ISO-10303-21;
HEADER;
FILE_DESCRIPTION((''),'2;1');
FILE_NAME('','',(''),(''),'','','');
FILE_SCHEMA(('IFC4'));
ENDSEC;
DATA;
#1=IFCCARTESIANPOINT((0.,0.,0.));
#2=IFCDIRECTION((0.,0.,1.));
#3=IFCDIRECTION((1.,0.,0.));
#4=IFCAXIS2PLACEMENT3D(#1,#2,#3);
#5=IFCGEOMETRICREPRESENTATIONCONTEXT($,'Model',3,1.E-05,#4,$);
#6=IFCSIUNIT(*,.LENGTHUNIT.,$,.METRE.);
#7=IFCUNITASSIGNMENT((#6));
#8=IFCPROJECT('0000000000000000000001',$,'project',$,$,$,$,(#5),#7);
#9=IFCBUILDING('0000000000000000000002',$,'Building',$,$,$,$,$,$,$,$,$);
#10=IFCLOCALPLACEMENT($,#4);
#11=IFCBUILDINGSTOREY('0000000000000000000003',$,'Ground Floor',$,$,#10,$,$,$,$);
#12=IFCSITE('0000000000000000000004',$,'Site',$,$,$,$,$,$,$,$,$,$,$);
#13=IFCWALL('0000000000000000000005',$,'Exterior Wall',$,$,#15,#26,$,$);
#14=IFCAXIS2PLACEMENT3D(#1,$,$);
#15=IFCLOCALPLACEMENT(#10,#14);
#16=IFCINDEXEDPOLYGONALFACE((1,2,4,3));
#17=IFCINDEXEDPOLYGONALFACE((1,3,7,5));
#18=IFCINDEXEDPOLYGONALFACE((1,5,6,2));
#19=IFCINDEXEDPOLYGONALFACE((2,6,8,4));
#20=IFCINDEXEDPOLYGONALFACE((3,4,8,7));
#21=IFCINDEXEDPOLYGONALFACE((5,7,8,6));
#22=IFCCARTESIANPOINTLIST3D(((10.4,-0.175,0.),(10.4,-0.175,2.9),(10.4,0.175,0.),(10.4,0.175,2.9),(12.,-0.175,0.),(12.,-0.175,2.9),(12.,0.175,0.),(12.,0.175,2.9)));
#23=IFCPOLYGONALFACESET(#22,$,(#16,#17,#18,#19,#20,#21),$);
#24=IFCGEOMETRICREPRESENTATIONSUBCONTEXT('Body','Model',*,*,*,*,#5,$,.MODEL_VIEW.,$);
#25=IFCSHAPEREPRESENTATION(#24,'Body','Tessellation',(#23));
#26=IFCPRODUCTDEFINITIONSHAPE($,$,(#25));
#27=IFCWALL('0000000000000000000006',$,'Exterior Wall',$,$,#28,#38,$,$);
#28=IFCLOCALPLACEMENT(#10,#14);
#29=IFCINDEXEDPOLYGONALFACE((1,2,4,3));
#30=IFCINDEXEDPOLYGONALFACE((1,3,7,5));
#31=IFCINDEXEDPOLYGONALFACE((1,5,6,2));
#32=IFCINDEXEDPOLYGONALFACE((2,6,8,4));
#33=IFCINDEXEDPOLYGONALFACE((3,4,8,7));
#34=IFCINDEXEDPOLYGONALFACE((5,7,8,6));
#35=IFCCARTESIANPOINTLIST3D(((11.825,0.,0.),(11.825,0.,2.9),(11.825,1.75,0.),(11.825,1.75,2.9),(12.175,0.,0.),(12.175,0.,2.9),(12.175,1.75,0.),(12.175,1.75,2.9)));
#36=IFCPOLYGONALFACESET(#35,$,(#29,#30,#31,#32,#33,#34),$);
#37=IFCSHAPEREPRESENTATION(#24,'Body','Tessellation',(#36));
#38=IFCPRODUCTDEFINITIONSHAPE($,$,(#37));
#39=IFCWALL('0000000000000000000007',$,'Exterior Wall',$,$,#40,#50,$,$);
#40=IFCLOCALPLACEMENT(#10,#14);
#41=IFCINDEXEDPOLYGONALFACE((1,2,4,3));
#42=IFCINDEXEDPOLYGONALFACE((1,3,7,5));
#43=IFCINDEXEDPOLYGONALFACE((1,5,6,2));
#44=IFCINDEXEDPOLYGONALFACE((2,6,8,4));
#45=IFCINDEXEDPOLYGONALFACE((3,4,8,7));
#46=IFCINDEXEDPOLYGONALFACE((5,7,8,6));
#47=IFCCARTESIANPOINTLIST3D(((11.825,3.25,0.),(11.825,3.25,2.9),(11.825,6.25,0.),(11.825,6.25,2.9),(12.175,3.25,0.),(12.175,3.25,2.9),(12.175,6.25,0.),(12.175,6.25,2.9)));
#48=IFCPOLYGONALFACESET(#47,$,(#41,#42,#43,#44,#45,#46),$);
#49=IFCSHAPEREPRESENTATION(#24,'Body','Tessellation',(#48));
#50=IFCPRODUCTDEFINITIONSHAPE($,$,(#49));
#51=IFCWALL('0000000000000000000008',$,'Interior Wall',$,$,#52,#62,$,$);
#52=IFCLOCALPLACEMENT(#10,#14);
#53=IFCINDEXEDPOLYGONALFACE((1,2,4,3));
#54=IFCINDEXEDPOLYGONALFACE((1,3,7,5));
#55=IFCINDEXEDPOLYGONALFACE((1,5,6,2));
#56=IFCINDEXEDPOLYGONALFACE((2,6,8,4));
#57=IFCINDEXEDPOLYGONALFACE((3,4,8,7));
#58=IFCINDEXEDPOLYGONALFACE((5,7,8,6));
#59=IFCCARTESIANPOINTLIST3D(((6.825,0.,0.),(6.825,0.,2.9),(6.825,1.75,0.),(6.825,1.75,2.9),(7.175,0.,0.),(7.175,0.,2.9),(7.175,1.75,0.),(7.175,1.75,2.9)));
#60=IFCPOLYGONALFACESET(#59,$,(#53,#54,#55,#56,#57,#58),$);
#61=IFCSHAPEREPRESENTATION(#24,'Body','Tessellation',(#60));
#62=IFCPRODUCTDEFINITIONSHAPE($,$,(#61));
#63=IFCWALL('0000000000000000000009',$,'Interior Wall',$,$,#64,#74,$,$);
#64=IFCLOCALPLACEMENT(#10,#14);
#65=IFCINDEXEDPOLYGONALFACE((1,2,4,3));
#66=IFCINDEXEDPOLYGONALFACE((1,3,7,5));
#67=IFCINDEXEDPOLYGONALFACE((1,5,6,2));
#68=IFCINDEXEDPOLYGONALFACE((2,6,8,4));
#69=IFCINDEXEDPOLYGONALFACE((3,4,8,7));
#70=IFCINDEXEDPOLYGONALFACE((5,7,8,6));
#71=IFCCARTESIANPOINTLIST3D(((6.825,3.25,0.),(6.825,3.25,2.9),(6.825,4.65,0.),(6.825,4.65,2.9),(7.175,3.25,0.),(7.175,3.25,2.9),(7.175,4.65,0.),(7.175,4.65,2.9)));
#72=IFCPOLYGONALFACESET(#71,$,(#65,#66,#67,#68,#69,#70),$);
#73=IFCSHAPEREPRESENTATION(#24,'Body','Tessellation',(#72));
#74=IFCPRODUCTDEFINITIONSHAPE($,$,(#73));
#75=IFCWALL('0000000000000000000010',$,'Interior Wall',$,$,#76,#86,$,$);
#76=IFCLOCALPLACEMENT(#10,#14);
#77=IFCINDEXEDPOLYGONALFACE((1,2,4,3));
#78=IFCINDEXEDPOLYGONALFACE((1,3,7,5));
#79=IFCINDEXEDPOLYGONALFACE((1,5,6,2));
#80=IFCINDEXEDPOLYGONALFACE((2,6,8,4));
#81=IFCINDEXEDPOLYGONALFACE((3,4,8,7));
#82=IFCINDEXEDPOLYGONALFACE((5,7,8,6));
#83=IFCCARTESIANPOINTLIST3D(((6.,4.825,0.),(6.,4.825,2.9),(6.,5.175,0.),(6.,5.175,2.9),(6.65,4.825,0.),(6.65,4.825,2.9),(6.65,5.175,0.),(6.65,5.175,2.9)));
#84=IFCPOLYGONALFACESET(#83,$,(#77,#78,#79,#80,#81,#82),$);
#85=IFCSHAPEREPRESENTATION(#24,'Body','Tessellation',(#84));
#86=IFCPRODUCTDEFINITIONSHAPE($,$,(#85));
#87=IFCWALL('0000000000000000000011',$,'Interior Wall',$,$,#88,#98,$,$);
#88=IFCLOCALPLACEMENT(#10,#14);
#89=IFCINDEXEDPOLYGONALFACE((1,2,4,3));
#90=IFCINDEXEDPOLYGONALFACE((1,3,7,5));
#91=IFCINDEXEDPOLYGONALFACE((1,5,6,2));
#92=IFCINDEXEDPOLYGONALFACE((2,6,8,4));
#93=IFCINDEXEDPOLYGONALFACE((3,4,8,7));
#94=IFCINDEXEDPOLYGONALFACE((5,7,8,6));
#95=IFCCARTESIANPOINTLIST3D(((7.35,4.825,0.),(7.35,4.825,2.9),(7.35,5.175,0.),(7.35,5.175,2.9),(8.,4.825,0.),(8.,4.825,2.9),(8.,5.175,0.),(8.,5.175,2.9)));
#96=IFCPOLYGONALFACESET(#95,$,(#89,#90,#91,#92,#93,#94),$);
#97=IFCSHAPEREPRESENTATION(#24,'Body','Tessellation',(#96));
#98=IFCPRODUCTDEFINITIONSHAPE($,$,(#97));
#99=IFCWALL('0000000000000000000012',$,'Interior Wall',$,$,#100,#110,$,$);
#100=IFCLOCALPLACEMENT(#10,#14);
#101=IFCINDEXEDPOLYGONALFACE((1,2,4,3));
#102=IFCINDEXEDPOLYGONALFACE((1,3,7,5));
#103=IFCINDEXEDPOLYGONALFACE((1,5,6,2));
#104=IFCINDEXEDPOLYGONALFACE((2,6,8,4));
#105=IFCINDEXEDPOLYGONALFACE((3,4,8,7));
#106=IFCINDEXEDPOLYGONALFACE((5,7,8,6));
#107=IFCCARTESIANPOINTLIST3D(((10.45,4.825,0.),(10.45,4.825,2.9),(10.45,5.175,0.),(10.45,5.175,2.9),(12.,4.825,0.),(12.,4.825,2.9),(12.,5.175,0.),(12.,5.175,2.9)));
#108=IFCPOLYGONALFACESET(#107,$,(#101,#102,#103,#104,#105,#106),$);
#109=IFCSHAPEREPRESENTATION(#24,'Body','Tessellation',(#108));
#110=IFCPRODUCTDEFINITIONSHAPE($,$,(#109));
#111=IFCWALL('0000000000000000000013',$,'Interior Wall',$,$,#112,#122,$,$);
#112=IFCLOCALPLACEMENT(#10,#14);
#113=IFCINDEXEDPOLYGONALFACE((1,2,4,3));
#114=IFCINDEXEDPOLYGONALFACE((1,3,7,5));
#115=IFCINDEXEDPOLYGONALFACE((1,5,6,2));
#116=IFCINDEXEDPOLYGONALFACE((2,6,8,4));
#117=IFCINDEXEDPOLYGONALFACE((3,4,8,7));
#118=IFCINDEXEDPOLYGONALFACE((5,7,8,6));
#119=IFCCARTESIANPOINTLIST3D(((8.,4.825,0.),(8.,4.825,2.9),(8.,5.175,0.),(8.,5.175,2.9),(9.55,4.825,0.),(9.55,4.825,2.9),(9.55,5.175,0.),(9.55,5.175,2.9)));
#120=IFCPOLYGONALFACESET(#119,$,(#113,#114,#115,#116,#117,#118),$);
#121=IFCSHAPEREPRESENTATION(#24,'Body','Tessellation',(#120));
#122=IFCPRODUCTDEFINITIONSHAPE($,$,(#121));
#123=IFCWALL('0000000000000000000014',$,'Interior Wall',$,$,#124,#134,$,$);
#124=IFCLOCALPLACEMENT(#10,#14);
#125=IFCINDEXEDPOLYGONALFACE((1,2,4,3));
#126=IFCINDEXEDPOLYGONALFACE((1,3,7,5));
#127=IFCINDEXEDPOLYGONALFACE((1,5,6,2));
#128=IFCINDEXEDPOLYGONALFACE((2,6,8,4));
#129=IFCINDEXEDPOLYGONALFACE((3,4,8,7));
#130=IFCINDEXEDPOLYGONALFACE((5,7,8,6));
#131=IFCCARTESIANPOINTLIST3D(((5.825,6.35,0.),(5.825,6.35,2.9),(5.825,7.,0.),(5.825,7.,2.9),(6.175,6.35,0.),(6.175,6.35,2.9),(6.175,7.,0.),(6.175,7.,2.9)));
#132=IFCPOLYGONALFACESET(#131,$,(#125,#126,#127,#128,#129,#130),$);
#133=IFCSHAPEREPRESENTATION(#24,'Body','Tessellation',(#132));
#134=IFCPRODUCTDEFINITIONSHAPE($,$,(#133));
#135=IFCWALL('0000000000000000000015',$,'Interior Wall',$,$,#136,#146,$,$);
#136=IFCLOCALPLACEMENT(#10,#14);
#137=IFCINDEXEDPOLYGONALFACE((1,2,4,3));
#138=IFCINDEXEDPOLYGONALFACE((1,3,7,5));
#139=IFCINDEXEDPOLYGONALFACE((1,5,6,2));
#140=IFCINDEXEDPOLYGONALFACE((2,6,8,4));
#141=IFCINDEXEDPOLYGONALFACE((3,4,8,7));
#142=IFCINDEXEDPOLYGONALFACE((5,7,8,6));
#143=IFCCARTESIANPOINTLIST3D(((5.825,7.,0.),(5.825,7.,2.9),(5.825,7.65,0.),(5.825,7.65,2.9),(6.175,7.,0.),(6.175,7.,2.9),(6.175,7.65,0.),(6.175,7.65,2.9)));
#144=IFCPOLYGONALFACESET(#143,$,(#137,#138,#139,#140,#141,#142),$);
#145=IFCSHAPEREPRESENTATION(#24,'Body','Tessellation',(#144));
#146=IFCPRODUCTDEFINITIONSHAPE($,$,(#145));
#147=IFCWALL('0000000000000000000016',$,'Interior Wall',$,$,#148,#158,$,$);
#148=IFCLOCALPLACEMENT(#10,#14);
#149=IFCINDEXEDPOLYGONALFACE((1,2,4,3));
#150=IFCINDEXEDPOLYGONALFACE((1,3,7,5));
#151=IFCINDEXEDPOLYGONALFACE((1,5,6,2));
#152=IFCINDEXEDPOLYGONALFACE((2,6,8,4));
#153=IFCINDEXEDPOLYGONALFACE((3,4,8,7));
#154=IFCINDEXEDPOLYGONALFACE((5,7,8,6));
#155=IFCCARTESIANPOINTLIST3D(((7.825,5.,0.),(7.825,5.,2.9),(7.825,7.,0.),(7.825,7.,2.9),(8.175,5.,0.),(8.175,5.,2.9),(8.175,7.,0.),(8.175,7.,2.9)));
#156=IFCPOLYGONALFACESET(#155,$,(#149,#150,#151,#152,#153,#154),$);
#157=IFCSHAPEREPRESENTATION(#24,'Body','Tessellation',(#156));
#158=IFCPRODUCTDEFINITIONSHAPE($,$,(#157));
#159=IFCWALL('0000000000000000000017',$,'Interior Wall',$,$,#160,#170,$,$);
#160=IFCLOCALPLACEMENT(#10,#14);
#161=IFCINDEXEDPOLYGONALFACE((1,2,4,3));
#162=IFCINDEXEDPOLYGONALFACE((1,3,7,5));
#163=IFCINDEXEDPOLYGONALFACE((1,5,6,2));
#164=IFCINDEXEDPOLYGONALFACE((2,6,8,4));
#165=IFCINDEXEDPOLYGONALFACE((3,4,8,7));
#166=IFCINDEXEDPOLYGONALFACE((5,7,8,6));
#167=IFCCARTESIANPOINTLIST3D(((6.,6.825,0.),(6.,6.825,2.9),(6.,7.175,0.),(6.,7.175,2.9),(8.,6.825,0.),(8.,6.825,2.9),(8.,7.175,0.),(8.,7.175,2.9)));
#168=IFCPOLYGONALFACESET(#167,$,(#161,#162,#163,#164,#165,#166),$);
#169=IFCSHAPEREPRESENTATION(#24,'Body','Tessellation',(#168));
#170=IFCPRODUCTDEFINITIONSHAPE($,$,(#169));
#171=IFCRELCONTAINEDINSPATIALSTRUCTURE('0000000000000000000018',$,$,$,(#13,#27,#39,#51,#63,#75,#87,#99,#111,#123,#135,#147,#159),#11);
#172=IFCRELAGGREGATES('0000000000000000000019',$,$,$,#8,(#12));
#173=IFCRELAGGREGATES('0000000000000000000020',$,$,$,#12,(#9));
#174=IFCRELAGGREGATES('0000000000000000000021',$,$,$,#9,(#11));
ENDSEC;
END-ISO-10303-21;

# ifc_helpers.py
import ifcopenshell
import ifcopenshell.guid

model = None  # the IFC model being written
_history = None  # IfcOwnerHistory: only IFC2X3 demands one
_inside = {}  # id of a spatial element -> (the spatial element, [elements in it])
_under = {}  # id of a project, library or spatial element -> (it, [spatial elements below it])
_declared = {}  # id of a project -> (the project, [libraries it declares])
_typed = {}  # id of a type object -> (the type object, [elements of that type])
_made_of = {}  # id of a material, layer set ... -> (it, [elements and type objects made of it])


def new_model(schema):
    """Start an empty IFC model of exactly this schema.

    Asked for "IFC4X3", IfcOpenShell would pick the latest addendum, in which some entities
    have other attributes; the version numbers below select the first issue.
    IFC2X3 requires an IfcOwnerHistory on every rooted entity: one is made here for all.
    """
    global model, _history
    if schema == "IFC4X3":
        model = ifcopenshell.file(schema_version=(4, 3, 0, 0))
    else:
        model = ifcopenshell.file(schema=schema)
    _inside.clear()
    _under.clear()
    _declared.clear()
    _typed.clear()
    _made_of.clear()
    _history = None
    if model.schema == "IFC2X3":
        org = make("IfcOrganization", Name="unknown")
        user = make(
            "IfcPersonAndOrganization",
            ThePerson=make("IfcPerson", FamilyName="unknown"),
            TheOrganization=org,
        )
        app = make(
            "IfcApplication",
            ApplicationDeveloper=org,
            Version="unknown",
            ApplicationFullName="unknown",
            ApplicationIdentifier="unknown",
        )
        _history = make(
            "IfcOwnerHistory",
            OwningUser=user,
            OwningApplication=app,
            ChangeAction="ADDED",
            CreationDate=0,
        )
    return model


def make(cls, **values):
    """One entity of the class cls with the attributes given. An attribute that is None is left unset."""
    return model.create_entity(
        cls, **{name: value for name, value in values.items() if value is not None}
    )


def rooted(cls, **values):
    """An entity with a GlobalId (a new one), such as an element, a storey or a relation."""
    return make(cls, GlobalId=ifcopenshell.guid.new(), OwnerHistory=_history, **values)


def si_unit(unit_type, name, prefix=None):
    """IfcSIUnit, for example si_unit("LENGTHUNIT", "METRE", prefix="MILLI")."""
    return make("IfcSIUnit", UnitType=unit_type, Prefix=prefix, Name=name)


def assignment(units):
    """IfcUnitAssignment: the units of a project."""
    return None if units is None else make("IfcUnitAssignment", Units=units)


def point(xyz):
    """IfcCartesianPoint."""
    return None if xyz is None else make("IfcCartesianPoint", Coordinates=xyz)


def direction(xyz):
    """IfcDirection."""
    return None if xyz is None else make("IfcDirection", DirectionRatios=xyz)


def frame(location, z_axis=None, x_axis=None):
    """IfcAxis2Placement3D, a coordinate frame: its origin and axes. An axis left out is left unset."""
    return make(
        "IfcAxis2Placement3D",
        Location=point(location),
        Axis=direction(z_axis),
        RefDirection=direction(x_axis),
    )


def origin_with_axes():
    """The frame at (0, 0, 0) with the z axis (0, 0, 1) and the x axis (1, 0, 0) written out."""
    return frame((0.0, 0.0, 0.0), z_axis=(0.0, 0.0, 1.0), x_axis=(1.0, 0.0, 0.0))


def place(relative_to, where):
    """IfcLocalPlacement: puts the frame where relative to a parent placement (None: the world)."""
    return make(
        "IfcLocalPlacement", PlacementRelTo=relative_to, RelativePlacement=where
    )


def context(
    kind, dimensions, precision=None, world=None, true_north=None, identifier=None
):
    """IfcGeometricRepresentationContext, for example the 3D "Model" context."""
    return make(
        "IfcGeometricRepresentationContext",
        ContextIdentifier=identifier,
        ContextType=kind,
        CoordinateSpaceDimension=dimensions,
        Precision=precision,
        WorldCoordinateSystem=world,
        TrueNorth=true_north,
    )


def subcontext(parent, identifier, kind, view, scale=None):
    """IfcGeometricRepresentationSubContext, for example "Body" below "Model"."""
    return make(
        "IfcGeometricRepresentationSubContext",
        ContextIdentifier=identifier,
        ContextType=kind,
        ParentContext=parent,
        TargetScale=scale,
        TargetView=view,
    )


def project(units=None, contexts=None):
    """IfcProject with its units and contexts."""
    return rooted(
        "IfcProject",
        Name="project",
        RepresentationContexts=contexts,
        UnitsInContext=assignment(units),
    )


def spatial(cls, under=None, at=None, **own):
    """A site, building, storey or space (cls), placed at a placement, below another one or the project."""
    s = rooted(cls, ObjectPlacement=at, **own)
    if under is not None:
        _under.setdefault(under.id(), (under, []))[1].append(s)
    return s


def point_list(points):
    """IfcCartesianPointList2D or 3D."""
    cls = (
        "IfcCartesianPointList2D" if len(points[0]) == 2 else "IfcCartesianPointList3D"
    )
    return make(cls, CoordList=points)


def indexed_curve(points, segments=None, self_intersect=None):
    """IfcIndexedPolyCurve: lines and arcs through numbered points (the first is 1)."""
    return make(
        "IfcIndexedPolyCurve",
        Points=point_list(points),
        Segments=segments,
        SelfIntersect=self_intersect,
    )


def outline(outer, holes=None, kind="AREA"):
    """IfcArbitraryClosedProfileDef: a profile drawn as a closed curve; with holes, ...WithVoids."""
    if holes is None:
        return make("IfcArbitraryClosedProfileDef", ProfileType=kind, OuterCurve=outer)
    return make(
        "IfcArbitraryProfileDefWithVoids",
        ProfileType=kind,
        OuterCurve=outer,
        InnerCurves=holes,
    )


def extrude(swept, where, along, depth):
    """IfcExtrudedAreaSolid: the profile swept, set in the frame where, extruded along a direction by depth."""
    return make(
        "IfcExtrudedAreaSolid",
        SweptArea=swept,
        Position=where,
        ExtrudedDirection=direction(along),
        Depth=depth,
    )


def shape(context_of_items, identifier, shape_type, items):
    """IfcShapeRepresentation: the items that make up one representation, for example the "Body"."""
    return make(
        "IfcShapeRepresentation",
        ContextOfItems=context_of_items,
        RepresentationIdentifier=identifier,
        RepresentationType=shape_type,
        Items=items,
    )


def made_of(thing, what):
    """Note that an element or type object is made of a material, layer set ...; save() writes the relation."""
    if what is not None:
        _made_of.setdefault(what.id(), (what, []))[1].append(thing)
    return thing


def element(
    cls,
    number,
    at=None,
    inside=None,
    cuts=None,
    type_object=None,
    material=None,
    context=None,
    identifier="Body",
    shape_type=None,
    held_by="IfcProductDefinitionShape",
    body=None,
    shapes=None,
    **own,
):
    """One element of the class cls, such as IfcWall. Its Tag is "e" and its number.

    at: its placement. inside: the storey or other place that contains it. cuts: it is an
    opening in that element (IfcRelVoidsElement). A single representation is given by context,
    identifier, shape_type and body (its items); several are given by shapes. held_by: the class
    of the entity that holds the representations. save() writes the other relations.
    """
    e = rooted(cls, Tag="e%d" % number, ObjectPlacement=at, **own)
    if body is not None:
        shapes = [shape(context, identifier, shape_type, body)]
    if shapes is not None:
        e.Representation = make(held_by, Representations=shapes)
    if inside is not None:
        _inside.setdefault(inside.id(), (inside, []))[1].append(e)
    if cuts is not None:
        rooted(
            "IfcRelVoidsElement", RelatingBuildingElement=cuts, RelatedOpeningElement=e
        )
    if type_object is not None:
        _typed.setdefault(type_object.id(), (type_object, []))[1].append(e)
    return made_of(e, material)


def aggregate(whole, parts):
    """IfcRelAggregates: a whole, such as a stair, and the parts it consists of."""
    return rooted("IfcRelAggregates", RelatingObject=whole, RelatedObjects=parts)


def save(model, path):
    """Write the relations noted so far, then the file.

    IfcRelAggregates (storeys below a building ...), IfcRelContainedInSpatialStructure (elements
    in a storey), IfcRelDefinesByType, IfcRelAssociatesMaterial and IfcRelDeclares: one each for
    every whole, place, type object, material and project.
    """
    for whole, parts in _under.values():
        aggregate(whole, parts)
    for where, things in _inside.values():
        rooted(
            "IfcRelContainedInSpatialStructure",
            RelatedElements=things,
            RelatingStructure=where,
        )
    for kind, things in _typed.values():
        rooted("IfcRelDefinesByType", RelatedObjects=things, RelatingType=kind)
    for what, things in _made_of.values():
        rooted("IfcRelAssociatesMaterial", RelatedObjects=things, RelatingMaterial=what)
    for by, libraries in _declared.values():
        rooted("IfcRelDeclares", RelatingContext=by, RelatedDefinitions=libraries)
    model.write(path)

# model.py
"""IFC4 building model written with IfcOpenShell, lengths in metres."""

from ifc_helpers import new_model, si_unit, frame, origin_with_axes, place, context, subcontext, project, spatial, indexed_curve, outline, extrude, element, save


model = new_model("IFC4")

# Units and contexts
model_context = context("Model", 3, precision=1e-05, world=origin_with_axes())
body_context = subcontext(model_context, "Body", "Model", "MODEL_VIEW")
ifc_project = project(units=[si_unit("LENGTHUNIT", "METRE")], contexts=[model_context])

# Site, building, storey
site = spatial("IfcSite", under=ifc_project, Name="Site")
building = spatial("IfcBuilding", under=site, Name="Building")
storey_placement = place(None, origin_with_axes())
storey = spatial("IfcBuildingStorey", under=building, at=storey_placement, Name="Ground Floor")

# Walls
wall_1_placement = place(storey_placement, frame((10.4, 0.0, 0.0), z_axis=(0.0, 0.0, 1.0), x_axis=(1.0, 0.0, 0.0)))
element("IfcWall", 1, at=wall_1_placement, inside=storey, Name="Exterior Wall", context=body_context, shape_type="SweptSolid", body=[
    extrude(outline(indexed_curve([(0.0, 0.0), (0.0, 0.35), (1.6, 0.35), (1.6, 0.0), (0.0, 0.0)], self_intersect=False)), frame((0.0, -0.175, 0.0), z_axis=(0.0, 0.0, 1.0), x_axis=(1.0, 0.0, 0.0)), (0.0, 0.0, 1.0), 2.9),
])
wall_2_placement = place(storey_placement, frame((12.0, 0.0, 0.0), z_axis=(0.0, 0.0, 1.0), x_axis=(0.0, 1.0, 0.0)))
element("IfcWall", 2, at=wall_2_placement, inside=storey, Name="Exterior Wall", context=body_context, shape_type="SweptSolid", body=[
    extrude(outline(indexed_curve([(0.0, 0.0), (0.0, 0.35), (1.75, 0.35), (1.75, 0.0), (0.0, 0.0)], self_intersect=False)), frame((0.0, -0.175, 0.0), z_axis=(0.0, 0.0, 1.0), x_axis=(1.0, 0.0, 0.0)), (0.0, 0.0, 1.0), 2.9),
])
wall_3_placement = place(storey_placement, frame((12.0, 3.25, 0.0), z_axis=(0.0, 0.0, 1.0), x_axis=(0.0, 1.0, 0.0)))
element("IfcWall", 3, at=wall_3_placement, inside=storey, Name="Exterior Wall", context=body_context, shape_type="SweptSolid", body=[
    extrude(outline(indexed_curve([(0.0, 0.0), (0.0, 0.35), (3.0, 0.35), (3.0, 0.0), (0.0, 0.0)], self_intersect=False)), frame((0.0, -0.175, 0.0), z_axis=(0.0, 0.0, 1.0), x_axis=(1.0, 0.0, 0.0)), (0.0, 0.0, 1.0), 2.9),
])
wall_4_placement = place(storey_placement, frame((7.0, 0.0, 0.0), z_axis=(0.0, 0.0, 1.0), x_axis=(0.0, 1.0, 0.0)))
element("IfcWall", 4, at=wall_4_placement, inside=storey, Name="Interior Wall", context=body_context, shape_type="SweptSolid", body=[
    extrude(outline(indexed_curve([(0.0, 0.0), (0.0, 0.35), (1.75, 0.35), (1.75, 0.0), (0.0, 0.0)], self_intersect=False)), frame((0.0, -0.175, 0.0), z_axis=(0.0, 0.0, 1.0), x_axis=(1.0, 0.0, 0.0)), (0.0, 0.0, 1.0), 2.9),
])
wall_5_placement = place(storey_placement, frame((7.0, 3.25, 0.0), z_axis=(0.0, 0.0, 1.0), x_axis=(0.0, 1.0, 0.0)))
element("IfcWall", 5, at=wall_5_placement, inside=storey, Name="Interior Wall", context=body_context, shape_type="SweptSolid", body=[
    extrude(outline(indexed_curve([(0.0, 0.0), (0.0, 0.35), (1.4, 0.35), (1.4, 0.0), (0.0, 0.0)], self_intersect=False)), frame((0.0, -0.175, 0.0), z_axis=(0.0, 0.0, 1.0), x_axis=(1.0, 0.0, 0.0)), (0.0, 0.0, 1.0), 2.9),
])
for number, where, z_axis, x_axis, name in (
    (6, (6.65, 5.0, 0.0), (0.0, 0.0, 1.0), (-1.0, 0.0, 0.0), "Interior Wall"),
    (7, (8.0, 5.0, 0.0), (0.0, 0.0, 1.0), (-1.0, 0.0, 0.0), "Interior Wall"),
):
    element("IfcWall", number, at=place(storey_placement, frame(where, z_axis=z_axis, x_axis=x_axis)), inside=storey, Name=name, context=body_context, shape_type="SweptSolid", body=[
        extrude(outline(indexed_curve([(0.0, 0.0), (0.0, 0.35), (0.65, 0.35), (0.65, 0.0), (0.0, 0.0)], self_intersect=False)), frame((0.0, -0.175, 0.0), z_axis=(0.0, 0.0, 1.0), x_axis=(1.0, 0.0, 0.0)), (0.0, 0.0, 1.0), 2.9),
    ])
for number, where, z_axis, x_axis, name in (
    (8, (12.0, 5.0, 0.0), (0.0, 0.0, 1.0), (-1.0, 0.0, 0.0), "Interior Wall"),
    (9, (9.55, 5.0, 0.0), (0.0, 0.0, 1.0), (-1.0, 0.0, 0.0), "Interior Wall"),
):
    element("IfcWall", number, at=place(storey_placement, frame(where, z_axis=z_axis, x_axis=x_axis)), inside=storey, Name=name, context=body_context, shape_type="SweptSolid", body=[
        extrude(outline(indexed_curve([(0.0, 0.0), (0.0, 0.35), (1.55, 0.35), (1.55, 0.0), (0.0, 0.0)], self_intersect=False)), frame((0.0, -0.175, 0.0), z_axis=(0.0, 0.0, 1.0), x_axis=(1.0, 0.0, 0.0)), (0.0, 0.0, 1.0), 2.9),
    ])
for number, where, z_axis, x_axis, name in (
    (10, (6.0, 6.35, 0.0), (0.0, 0.0, 1.0), (0.0, 1.0, 0.0), "Interior Wall"),
    (11, (6.0, 7.0, 0.0), (0.0, 0.0, 1.0), (0.0, 1.0, 0.0), "Interior Wall"),
):
    element("IfcWall", number, at=place(storey_placement, frame(where, z_axis=z_axis, x_axis=x_axis)), inside=storey, Name=name, context=body_context, shape_type="SweptSolid", body=[
        extrude(outline(indexed_curve([(0.0, 0.0), (0.0, 0.35), (0.65, 0.35), (0.65, 0.0), (0.0, 0.0)], self_intersect=False)), frame((0.0, -0.175, 0.0), z_axis=(0.0, 0.0, 1.0), x_axis=(1.0, 0.0, 0.0)), (0.0, 0.0, 1.0), 2.9),
    ])
for number, where, z_axis, x_axis, name in (
    (12, (8.0, 5.0, 0.0), (0.0, 0.0, 1.0), (0.0, 1.0, 0.0), "Interior Wall"),
    (13, (8.0, 7.0, 0.0), (0.0, 0.0, 1.0), (-1.0, 0.0, 0.0), "Interior Wall"),
):
    element("IfcWall", number, at=place(storey_placement, frame(where, z_axis=z_axis, x_axis=x_axis)), inside=storey, Name=name, context=body_context, shape_type="SweptSolid", body=[
        extrude(outline(indexed_curve([(0.0, 0.0), (0.0, 0.35), (2.0, 0.35), (2.0, 0.0), (0.0, 0.0)], self_intersect=False)), frame((0.0, -0.175, 0.0), z_axis=(0.0, 0.0, 1.0), x_axis=(1.0, 0.0, 0.0)), (0.0, 0.0, 1.0), 2.9),
    ])

save(model, "model.ifc")
